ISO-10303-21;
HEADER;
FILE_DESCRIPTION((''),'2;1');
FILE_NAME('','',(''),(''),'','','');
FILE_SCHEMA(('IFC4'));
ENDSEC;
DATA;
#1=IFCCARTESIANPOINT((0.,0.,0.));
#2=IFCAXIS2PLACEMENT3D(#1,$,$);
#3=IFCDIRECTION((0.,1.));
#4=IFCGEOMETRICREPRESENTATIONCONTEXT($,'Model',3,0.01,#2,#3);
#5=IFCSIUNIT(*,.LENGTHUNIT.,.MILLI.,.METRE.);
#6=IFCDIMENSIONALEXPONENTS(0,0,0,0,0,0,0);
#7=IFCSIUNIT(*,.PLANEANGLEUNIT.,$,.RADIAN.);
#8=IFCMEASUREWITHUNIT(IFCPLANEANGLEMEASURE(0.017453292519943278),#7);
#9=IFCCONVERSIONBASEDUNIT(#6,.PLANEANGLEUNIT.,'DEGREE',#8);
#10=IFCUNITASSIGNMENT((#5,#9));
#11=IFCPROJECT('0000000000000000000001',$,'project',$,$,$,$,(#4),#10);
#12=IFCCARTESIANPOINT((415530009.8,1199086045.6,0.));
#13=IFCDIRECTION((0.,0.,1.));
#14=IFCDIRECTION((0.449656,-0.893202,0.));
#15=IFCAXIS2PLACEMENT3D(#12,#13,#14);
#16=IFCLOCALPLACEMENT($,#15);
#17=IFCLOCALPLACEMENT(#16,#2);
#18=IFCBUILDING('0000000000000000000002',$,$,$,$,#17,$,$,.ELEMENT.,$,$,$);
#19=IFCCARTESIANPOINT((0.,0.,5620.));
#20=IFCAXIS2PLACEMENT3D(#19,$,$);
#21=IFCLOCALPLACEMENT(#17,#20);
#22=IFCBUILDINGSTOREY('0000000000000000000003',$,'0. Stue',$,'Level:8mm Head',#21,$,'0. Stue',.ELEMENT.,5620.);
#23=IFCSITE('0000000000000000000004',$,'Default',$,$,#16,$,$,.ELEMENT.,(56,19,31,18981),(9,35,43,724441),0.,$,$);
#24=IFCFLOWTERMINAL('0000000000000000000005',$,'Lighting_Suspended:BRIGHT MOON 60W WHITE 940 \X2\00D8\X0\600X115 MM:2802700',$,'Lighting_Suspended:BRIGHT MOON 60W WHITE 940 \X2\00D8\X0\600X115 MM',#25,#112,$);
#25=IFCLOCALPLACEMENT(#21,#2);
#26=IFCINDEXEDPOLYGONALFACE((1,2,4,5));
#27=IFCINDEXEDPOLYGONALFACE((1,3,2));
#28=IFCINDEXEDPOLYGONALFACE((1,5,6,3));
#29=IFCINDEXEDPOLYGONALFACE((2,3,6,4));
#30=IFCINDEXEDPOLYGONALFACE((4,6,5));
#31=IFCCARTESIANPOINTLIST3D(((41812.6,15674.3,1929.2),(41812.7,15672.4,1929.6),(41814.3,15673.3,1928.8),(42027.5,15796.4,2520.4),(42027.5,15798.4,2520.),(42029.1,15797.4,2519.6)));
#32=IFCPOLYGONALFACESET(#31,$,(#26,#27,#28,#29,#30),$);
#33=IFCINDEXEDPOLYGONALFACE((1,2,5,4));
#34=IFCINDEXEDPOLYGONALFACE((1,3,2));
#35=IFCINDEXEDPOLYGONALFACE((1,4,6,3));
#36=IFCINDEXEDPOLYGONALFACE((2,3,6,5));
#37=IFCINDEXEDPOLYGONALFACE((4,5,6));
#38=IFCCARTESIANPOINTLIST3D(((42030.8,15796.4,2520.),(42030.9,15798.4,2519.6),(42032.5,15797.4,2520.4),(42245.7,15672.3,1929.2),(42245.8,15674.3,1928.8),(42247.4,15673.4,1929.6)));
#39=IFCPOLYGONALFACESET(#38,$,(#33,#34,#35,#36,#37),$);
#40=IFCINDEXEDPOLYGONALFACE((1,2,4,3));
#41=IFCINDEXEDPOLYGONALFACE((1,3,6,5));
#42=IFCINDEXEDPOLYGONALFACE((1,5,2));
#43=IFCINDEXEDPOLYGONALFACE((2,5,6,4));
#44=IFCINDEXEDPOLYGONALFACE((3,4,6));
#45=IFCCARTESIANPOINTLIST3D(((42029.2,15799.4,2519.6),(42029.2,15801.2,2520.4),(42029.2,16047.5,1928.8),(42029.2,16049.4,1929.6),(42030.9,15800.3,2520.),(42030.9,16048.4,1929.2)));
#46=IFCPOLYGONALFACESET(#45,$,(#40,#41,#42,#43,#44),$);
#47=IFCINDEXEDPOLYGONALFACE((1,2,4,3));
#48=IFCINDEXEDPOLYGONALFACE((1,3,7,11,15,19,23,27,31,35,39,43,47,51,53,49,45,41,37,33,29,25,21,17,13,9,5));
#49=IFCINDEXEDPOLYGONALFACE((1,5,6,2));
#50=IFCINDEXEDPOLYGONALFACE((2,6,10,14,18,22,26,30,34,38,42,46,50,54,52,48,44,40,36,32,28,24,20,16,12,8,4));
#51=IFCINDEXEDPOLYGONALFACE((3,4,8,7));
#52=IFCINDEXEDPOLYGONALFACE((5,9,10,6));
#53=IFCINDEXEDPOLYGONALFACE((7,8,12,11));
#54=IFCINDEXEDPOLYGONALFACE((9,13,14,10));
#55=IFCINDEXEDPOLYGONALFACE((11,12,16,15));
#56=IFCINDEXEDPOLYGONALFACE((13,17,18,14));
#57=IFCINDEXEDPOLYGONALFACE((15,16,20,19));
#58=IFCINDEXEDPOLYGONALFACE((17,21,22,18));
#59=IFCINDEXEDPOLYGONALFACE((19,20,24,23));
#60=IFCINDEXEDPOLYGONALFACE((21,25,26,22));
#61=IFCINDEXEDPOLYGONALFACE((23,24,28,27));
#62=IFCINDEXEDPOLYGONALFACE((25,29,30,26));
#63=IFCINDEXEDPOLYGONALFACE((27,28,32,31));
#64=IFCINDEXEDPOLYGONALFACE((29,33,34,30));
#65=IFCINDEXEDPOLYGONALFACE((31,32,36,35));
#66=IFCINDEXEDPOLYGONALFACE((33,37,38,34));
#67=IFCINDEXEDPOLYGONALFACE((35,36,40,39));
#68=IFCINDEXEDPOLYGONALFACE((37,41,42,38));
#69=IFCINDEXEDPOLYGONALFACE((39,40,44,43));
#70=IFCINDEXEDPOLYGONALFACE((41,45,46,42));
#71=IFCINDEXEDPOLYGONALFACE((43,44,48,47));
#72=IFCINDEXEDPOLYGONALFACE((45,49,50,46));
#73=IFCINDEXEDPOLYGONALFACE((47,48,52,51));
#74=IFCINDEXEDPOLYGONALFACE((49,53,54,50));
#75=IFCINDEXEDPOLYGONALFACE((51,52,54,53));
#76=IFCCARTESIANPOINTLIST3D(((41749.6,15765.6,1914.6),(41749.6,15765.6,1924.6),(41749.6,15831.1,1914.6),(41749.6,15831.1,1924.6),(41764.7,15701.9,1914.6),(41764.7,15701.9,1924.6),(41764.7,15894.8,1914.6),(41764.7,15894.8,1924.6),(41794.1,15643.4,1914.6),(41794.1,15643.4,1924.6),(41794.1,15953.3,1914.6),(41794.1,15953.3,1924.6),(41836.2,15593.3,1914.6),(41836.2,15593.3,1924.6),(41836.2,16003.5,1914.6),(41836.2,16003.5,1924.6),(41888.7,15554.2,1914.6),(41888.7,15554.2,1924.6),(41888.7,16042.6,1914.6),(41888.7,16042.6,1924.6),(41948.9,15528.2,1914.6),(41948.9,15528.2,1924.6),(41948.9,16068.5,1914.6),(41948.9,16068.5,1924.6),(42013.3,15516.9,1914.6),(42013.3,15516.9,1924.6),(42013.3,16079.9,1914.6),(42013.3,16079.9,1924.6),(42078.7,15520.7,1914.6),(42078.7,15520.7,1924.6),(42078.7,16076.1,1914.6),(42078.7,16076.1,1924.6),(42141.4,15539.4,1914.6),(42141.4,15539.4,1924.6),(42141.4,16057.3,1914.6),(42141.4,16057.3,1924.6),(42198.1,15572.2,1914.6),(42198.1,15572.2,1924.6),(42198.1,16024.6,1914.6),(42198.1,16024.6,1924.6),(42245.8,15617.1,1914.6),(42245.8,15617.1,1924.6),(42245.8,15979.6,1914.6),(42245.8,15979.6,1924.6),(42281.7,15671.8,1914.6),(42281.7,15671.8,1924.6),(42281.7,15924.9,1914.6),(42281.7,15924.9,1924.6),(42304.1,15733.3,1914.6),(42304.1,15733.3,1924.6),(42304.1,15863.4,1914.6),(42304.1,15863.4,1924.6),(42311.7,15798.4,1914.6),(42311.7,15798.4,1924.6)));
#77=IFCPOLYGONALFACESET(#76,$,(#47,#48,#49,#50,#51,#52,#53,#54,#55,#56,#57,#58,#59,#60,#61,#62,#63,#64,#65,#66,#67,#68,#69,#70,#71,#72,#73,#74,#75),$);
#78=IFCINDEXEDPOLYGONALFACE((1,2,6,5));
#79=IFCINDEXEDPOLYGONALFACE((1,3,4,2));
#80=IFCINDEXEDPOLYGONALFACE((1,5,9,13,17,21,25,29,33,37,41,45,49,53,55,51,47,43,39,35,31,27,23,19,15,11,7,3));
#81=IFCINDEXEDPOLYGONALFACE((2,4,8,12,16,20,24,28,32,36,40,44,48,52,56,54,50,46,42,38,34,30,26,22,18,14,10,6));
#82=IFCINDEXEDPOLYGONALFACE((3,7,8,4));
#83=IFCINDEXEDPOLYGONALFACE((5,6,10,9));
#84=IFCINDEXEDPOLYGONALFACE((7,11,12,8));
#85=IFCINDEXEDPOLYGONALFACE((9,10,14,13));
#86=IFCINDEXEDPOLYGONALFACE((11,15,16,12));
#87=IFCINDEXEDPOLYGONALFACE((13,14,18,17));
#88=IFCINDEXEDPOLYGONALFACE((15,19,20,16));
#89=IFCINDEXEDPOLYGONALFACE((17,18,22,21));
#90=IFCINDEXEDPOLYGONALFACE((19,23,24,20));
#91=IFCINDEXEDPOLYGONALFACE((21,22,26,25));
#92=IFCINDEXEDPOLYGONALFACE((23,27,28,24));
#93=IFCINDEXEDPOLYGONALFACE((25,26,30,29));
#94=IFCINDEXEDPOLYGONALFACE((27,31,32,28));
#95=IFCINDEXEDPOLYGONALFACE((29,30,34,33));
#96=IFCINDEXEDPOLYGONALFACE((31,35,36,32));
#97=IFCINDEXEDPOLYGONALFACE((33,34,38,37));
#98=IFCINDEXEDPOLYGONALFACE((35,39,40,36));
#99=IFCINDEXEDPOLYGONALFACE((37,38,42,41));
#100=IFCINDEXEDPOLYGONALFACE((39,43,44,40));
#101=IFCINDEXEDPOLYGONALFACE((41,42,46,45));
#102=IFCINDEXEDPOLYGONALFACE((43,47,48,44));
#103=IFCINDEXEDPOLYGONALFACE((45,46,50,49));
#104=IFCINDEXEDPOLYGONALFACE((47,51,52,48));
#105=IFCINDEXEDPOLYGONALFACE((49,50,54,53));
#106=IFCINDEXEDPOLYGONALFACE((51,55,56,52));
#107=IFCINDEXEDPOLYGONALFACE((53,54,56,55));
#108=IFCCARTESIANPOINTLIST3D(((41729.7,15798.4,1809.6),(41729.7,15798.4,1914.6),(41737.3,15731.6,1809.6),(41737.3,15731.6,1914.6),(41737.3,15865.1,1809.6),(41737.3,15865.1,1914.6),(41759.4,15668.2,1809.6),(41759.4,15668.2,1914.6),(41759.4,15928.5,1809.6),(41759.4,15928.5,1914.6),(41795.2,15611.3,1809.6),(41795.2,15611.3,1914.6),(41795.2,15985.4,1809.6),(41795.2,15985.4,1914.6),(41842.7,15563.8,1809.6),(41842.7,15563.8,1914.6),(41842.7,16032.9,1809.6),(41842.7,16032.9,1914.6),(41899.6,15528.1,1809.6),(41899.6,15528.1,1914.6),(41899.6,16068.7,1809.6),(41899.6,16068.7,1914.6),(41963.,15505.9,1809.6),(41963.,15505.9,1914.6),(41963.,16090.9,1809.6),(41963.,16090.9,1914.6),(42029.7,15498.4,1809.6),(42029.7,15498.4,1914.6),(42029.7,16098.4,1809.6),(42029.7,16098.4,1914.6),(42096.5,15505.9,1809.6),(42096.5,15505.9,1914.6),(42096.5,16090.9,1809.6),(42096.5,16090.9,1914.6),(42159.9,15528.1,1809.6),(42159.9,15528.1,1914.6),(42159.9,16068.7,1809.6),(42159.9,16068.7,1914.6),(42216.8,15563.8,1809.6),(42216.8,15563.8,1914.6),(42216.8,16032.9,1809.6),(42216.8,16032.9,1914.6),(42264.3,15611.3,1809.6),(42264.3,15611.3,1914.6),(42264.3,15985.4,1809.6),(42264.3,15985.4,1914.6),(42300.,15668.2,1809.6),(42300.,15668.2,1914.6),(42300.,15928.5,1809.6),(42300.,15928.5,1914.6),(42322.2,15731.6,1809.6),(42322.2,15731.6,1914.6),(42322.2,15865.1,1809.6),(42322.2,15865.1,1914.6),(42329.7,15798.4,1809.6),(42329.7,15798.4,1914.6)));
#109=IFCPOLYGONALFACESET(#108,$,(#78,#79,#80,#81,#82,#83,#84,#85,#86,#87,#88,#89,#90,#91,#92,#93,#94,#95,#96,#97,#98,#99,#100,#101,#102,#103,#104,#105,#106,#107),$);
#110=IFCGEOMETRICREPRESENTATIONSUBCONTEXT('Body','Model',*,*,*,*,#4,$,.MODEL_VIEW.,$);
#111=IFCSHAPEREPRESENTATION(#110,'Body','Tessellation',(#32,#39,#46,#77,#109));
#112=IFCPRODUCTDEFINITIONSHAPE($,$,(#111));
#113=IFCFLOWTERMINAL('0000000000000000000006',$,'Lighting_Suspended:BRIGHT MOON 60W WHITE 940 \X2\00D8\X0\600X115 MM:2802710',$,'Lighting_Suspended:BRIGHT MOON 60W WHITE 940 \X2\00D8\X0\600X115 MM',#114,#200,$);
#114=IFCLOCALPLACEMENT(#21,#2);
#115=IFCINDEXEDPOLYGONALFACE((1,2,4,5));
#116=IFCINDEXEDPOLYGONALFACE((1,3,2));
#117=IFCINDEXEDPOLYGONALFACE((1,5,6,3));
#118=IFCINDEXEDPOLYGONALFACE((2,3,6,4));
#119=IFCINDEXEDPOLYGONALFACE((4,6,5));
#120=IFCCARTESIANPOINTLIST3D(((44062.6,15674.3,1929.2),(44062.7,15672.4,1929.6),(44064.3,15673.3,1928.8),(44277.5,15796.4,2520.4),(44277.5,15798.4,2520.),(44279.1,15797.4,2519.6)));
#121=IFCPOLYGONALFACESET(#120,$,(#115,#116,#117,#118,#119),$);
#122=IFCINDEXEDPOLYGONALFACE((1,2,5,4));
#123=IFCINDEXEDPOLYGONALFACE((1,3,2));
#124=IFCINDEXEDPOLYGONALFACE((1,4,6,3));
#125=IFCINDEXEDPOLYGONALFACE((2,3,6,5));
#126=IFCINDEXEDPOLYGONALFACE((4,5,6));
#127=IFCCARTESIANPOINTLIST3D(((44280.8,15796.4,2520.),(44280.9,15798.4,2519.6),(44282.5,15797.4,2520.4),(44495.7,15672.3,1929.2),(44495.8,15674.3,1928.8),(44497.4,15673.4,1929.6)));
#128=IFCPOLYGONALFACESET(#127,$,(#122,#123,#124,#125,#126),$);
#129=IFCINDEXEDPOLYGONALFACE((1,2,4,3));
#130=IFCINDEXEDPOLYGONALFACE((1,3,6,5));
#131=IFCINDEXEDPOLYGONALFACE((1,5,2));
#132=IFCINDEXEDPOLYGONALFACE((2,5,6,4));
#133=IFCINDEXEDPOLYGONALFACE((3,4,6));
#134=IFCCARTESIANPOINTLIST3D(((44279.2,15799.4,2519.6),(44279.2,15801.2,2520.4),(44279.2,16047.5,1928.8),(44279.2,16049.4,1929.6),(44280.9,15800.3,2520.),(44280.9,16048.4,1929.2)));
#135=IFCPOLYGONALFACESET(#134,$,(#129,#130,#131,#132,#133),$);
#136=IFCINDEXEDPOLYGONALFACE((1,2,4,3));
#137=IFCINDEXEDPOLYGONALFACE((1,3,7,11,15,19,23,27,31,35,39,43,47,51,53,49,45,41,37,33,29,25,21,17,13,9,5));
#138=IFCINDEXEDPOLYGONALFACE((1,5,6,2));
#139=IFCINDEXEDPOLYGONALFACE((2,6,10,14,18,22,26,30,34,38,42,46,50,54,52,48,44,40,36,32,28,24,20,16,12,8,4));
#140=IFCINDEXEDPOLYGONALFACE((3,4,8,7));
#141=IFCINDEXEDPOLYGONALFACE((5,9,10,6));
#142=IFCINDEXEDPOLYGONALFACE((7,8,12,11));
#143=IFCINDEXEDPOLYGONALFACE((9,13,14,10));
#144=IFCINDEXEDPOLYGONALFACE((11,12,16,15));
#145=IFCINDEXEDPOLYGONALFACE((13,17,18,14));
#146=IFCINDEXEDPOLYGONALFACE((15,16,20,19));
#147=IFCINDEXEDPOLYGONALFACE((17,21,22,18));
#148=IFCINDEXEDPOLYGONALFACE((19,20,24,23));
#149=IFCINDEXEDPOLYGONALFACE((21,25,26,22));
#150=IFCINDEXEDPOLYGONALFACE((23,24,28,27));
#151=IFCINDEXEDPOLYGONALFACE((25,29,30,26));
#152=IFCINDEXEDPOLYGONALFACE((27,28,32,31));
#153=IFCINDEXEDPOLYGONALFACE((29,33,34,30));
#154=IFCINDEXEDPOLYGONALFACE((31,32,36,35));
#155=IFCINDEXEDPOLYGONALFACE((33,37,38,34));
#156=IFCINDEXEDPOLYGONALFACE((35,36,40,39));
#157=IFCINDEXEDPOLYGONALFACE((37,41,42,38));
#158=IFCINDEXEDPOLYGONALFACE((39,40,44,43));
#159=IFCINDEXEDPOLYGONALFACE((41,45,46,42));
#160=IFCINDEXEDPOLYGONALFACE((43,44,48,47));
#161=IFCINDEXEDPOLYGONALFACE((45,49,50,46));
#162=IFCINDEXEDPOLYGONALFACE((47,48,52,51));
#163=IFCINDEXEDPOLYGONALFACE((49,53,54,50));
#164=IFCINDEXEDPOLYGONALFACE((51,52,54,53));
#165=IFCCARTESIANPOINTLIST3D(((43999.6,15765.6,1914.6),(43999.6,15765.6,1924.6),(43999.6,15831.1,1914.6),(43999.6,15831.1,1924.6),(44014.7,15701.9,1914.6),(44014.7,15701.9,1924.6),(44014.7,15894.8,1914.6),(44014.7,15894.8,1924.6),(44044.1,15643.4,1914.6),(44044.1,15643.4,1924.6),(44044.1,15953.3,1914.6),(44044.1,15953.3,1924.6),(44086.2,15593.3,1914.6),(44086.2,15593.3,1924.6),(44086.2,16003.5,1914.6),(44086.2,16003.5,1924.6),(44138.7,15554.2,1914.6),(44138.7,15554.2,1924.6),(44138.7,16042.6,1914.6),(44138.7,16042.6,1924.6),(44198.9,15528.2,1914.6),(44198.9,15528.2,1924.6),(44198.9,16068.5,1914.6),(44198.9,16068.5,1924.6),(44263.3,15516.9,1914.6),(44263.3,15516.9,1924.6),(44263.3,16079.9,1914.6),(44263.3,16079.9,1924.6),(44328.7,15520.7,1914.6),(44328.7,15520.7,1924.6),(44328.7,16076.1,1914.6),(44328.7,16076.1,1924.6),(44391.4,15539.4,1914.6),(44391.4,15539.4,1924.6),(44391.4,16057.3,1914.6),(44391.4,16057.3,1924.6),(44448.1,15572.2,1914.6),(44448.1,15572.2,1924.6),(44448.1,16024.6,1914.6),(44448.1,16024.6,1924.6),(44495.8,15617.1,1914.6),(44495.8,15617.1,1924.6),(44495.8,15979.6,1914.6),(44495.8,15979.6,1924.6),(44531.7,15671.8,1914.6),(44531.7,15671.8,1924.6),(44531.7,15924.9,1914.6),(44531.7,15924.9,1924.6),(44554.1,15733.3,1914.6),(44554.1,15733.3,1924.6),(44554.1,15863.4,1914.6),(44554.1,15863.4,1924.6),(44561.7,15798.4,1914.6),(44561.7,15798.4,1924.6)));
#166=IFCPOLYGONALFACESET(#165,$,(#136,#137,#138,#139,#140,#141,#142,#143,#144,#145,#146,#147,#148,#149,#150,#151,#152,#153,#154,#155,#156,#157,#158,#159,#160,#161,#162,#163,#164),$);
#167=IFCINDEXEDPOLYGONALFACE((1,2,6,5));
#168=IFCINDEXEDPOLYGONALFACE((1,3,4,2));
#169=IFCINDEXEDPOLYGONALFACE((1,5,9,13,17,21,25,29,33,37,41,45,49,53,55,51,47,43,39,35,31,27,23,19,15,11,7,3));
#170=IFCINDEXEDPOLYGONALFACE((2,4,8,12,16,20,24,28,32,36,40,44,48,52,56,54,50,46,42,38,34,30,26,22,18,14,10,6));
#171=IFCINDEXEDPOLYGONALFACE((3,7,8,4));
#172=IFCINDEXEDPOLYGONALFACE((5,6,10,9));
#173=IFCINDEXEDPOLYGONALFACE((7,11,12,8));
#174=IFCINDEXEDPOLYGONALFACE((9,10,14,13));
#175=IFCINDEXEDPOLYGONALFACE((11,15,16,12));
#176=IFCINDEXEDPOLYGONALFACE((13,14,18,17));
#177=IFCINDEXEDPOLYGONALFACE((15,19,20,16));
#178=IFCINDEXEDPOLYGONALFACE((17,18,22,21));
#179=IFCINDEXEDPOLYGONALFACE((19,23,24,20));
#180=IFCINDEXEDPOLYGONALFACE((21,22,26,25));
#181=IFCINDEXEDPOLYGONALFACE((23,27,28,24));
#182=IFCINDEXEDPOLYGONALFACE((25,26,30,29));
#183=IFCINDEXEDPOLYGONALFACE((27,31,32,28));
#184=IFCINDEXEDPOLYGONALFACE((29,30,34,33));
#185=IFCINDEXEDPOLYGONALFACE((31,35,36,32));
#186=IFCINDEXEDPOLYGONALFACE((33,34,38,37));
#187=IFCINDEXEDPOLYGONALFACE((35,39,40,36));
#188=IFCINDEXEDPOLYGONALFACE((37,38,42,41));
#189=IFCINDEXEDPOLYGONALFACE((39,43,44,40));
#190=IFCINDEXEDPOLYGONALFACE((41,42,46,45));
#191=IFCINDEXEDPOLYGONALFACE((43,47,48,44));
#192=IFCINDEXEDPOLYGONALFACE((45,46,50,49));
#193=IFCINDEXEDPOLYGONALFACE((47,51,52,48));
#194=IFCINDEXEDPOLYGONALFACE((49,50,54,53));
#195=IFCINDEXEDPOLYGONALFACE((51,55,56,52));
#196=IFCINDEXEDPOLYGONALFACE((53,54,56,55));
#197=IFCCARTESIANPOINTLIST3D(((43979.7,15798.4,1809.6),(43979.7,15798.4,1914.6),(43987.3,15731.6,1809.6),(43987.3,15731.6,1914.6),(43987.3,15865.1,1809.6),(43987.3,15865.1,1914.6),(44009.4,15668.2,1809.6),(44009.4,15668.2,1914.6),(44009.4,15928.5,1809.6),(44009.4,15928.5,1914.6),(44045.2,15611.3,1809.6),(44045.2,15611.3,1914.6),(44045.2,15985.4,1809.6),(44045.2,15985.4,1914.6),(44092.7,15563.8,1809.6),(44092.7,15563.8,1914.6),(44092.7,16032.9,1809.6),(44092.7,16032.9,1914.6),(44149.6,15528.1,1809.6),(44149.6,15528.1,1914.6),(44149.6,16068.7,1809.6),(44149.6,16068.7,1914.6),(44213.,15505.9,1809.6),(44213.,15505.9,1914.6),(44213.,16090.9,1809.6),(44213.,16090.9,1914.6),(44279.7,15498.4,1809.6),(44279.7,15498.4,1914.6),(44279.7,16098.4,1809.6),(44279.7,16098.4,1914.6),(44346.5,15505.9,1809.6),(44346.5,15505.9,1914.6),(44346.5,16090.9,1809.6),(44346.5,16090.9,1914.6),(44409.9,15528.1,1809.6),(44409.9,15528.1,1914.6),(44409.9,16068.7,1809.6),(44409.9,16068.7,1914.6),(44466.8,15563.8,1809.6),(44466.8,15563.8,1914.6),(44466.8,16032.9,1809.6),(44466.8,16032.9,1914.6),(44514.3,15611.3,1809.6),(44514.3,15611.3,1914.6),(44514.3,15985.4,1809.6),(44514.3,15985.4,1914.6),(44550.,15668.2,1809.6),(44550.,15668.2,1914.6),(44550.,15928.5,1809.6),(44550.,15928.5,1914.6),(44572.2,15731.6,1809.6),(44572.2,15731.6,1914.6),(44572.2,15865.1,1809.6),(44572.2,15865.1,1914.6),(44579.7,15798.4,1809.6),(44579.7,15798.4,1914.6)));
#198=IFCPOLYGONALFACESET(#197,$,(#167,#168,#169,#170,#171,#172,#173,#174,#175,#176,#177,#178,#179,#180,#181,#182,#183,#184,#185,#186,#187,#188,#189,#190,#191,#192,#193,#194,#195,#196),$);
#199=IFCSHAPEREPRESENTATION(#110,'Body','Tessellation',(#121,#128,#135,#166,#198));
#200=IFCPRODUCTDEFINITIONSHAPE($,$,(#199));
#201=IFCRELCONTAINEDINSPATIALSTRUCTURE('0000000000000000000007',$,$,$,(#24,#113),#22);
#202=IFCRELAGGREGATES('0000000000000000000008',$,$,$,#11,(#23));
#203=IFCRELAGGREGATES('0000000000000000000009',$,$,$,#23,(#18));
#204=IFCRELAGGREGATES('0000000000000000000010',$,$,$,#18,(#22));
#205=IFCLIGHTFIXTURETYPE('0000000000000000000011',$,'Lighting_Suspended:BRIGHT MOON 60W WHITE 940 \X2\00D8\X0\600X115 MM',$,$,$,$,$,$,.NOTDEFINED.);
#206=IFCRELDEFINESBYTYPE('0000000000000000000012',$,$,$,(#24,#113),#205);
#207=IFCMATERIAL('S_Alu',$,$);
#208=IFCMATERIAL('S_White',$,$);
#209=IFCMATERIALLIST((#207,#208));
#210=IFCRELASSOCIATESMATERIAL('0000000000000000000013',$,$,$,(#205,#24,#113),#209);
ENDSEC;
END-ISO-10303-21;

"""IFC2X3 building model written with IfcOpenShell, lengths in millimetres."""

from ifc_helpers import new_model, entity, si_unit, converted_unit, direction, frame, frame_2d, origin, place, context, subcontext, project, spatial, polyline, circle, outline, extrude, source, transform, mapped, material, material_list, type_object, type_shapes, element, save


model = new_model("IFC2X3")

# Units and contexts
model_context = context("Model", 3, precision=0.01, world=origin(), true_north=direction((0.0, 1.0)))
body_context = subcontext(model_context, "Body", "Model", "MODEL_VIEW")
ifc_project = project(units=[si_unit("LENGTHUNIT", "METRE", prefix="MILLI"), converted_unit("PLANEANGLEUNIT", "DEGREE", entity("IfcPlaneAngleMeasure", 0.017453292519943278), si_unit("PLANEANGLEUNIT", "RADIAN"), dimensions=[0, 0, 0, 0, 0, 0, 0])], contexts=[model_context])

# Site, building, storey
site_placement = place(None, frame((415530009.8, 1199086045.6, 0.0), z_axis=(0.0, 0.0, 1.0), x_axis=(0.449656, -0.893202, 0.0)))
site = spatial("IfcSite", under=ifc_project, at=site_placement, Name="Default", CompositionType="ELEMENT", RefLatitude=(56, 19, 31, 18981), RefLongitude=(9, 35, 43, 724441), RefElevation=0.0)
building_placement = place(site_placement, origin())
building = spatial("IfcBuilding", under=site, at=building_placement, CompositionType="ELEMENT")
storey_placement = place(building_placement, frame((0.0, 0.0, 5620.0)))
storey = spatial("IfcBuildingStorey", under=building, at=storey_placement, Name="0. Stue", ObjectType="Level:8mm Head", LongName="0. Stue", CompositionType="ELEMENT", Elevation=5620.0)

# Flow terminals
ifc_material_1 = material(Name="S_Alu")
ifc_material_2 = material(Name="S_White")
ifc_material_list = material_list([ifc_material_1, ifc_material_2])
light_fixture_type_1 = type_object("IfcLightFixtureType", Name="Lighting_Suspended:BRIGHT MOON 60W WHITE 940 Ø600X115 MM", PredefinedType="NOTDEFINED", material=ifc_material_list)
shared_shape_1 = source(origin(), body_context, "Body", "SweptSolid", [
    extrude(outline(polyline([(-1.0, -0.6), (1.0, -0.6), (0.0, 1.2), (-1.0, -0.6)])), frame((-216.6, -125.0, -595.4), z_axis=(0.335353, 0.193616, 0.921982), x_axis=(-0.832243, 0.519504, 0.193616)), (0.0, 0.0, 1.0), 640.8),
    extrude(outline(polyline([(-1.0, -0.6), (1.0, -0.6), (0.0, 1.2), (-1.0, -0.6)])), frame((216.6, -125.0, -595.4), z_axis=(-0.335353, 0.193616, 0.921982), x_axis=(-0.033783, -0.980496, 0.193616)), (0.0, 0.0, 1.0), 640.8),
    extrude(outline(polyline([(-1.0, -0.6), (1.0, -0.6), (0.0, 1.2), (-1.0, -0.6)])), frame((0.0, 250.1, -595.4), z_axis=(0.0, -0.387232, 0.921982), x_axis=(0.866025, 0.460991, 0.193616)), (0.0, 0.0, 1.0), 640.8),
    extrude(circle(Radius=282.0, at=frame_2d((0.0, 0.0), x_axis=(1.0, 0.0))), frame((0.0, 0.0, -610.0)), (0.0, 0.0, 1.0), 10.0),
    extrude(circle(Radius=300.0, at=frame_2d((0.0, 0.0), x_axis=(1.0, 0.0))), frame((0.0, 0.0, -715.0)), (0.0, 0.0, 1.0), 105.0),
])
type_shapes(light_fixture_type_1, [shared_shape_1])
for number, where, name in (
    (1, (42029.7, 15798.4, 2524.6), "Lighting_Suspended:BRIGHT MOON 60W WHITE 940 Ø600X115 MM:2802700"),
    (2, (44279.7, 15798.4, 2524.6), "Lighting_Suspended:BRIGHT MOON 60W WHITE 940 Ø600X115 MM:2802710"),
):
    element("IfcFlowTerminal", number, at=place(storey_placement, frame(where)), inside=storey, type_object=light_fixture_type_1, material=ifc_material_list, Name=name, ObjectType="Lighting_Suspended:BRIGHT MOON 60W WHITE 940 Ø600X115 MM", context=body_context, shape_type="MappedRepresentation", body=[
        mapped(shared_shape_1, transform((0.0, 0.0, 0.0), scale=1.0)),
    ])

save(model, "model.ifc")
